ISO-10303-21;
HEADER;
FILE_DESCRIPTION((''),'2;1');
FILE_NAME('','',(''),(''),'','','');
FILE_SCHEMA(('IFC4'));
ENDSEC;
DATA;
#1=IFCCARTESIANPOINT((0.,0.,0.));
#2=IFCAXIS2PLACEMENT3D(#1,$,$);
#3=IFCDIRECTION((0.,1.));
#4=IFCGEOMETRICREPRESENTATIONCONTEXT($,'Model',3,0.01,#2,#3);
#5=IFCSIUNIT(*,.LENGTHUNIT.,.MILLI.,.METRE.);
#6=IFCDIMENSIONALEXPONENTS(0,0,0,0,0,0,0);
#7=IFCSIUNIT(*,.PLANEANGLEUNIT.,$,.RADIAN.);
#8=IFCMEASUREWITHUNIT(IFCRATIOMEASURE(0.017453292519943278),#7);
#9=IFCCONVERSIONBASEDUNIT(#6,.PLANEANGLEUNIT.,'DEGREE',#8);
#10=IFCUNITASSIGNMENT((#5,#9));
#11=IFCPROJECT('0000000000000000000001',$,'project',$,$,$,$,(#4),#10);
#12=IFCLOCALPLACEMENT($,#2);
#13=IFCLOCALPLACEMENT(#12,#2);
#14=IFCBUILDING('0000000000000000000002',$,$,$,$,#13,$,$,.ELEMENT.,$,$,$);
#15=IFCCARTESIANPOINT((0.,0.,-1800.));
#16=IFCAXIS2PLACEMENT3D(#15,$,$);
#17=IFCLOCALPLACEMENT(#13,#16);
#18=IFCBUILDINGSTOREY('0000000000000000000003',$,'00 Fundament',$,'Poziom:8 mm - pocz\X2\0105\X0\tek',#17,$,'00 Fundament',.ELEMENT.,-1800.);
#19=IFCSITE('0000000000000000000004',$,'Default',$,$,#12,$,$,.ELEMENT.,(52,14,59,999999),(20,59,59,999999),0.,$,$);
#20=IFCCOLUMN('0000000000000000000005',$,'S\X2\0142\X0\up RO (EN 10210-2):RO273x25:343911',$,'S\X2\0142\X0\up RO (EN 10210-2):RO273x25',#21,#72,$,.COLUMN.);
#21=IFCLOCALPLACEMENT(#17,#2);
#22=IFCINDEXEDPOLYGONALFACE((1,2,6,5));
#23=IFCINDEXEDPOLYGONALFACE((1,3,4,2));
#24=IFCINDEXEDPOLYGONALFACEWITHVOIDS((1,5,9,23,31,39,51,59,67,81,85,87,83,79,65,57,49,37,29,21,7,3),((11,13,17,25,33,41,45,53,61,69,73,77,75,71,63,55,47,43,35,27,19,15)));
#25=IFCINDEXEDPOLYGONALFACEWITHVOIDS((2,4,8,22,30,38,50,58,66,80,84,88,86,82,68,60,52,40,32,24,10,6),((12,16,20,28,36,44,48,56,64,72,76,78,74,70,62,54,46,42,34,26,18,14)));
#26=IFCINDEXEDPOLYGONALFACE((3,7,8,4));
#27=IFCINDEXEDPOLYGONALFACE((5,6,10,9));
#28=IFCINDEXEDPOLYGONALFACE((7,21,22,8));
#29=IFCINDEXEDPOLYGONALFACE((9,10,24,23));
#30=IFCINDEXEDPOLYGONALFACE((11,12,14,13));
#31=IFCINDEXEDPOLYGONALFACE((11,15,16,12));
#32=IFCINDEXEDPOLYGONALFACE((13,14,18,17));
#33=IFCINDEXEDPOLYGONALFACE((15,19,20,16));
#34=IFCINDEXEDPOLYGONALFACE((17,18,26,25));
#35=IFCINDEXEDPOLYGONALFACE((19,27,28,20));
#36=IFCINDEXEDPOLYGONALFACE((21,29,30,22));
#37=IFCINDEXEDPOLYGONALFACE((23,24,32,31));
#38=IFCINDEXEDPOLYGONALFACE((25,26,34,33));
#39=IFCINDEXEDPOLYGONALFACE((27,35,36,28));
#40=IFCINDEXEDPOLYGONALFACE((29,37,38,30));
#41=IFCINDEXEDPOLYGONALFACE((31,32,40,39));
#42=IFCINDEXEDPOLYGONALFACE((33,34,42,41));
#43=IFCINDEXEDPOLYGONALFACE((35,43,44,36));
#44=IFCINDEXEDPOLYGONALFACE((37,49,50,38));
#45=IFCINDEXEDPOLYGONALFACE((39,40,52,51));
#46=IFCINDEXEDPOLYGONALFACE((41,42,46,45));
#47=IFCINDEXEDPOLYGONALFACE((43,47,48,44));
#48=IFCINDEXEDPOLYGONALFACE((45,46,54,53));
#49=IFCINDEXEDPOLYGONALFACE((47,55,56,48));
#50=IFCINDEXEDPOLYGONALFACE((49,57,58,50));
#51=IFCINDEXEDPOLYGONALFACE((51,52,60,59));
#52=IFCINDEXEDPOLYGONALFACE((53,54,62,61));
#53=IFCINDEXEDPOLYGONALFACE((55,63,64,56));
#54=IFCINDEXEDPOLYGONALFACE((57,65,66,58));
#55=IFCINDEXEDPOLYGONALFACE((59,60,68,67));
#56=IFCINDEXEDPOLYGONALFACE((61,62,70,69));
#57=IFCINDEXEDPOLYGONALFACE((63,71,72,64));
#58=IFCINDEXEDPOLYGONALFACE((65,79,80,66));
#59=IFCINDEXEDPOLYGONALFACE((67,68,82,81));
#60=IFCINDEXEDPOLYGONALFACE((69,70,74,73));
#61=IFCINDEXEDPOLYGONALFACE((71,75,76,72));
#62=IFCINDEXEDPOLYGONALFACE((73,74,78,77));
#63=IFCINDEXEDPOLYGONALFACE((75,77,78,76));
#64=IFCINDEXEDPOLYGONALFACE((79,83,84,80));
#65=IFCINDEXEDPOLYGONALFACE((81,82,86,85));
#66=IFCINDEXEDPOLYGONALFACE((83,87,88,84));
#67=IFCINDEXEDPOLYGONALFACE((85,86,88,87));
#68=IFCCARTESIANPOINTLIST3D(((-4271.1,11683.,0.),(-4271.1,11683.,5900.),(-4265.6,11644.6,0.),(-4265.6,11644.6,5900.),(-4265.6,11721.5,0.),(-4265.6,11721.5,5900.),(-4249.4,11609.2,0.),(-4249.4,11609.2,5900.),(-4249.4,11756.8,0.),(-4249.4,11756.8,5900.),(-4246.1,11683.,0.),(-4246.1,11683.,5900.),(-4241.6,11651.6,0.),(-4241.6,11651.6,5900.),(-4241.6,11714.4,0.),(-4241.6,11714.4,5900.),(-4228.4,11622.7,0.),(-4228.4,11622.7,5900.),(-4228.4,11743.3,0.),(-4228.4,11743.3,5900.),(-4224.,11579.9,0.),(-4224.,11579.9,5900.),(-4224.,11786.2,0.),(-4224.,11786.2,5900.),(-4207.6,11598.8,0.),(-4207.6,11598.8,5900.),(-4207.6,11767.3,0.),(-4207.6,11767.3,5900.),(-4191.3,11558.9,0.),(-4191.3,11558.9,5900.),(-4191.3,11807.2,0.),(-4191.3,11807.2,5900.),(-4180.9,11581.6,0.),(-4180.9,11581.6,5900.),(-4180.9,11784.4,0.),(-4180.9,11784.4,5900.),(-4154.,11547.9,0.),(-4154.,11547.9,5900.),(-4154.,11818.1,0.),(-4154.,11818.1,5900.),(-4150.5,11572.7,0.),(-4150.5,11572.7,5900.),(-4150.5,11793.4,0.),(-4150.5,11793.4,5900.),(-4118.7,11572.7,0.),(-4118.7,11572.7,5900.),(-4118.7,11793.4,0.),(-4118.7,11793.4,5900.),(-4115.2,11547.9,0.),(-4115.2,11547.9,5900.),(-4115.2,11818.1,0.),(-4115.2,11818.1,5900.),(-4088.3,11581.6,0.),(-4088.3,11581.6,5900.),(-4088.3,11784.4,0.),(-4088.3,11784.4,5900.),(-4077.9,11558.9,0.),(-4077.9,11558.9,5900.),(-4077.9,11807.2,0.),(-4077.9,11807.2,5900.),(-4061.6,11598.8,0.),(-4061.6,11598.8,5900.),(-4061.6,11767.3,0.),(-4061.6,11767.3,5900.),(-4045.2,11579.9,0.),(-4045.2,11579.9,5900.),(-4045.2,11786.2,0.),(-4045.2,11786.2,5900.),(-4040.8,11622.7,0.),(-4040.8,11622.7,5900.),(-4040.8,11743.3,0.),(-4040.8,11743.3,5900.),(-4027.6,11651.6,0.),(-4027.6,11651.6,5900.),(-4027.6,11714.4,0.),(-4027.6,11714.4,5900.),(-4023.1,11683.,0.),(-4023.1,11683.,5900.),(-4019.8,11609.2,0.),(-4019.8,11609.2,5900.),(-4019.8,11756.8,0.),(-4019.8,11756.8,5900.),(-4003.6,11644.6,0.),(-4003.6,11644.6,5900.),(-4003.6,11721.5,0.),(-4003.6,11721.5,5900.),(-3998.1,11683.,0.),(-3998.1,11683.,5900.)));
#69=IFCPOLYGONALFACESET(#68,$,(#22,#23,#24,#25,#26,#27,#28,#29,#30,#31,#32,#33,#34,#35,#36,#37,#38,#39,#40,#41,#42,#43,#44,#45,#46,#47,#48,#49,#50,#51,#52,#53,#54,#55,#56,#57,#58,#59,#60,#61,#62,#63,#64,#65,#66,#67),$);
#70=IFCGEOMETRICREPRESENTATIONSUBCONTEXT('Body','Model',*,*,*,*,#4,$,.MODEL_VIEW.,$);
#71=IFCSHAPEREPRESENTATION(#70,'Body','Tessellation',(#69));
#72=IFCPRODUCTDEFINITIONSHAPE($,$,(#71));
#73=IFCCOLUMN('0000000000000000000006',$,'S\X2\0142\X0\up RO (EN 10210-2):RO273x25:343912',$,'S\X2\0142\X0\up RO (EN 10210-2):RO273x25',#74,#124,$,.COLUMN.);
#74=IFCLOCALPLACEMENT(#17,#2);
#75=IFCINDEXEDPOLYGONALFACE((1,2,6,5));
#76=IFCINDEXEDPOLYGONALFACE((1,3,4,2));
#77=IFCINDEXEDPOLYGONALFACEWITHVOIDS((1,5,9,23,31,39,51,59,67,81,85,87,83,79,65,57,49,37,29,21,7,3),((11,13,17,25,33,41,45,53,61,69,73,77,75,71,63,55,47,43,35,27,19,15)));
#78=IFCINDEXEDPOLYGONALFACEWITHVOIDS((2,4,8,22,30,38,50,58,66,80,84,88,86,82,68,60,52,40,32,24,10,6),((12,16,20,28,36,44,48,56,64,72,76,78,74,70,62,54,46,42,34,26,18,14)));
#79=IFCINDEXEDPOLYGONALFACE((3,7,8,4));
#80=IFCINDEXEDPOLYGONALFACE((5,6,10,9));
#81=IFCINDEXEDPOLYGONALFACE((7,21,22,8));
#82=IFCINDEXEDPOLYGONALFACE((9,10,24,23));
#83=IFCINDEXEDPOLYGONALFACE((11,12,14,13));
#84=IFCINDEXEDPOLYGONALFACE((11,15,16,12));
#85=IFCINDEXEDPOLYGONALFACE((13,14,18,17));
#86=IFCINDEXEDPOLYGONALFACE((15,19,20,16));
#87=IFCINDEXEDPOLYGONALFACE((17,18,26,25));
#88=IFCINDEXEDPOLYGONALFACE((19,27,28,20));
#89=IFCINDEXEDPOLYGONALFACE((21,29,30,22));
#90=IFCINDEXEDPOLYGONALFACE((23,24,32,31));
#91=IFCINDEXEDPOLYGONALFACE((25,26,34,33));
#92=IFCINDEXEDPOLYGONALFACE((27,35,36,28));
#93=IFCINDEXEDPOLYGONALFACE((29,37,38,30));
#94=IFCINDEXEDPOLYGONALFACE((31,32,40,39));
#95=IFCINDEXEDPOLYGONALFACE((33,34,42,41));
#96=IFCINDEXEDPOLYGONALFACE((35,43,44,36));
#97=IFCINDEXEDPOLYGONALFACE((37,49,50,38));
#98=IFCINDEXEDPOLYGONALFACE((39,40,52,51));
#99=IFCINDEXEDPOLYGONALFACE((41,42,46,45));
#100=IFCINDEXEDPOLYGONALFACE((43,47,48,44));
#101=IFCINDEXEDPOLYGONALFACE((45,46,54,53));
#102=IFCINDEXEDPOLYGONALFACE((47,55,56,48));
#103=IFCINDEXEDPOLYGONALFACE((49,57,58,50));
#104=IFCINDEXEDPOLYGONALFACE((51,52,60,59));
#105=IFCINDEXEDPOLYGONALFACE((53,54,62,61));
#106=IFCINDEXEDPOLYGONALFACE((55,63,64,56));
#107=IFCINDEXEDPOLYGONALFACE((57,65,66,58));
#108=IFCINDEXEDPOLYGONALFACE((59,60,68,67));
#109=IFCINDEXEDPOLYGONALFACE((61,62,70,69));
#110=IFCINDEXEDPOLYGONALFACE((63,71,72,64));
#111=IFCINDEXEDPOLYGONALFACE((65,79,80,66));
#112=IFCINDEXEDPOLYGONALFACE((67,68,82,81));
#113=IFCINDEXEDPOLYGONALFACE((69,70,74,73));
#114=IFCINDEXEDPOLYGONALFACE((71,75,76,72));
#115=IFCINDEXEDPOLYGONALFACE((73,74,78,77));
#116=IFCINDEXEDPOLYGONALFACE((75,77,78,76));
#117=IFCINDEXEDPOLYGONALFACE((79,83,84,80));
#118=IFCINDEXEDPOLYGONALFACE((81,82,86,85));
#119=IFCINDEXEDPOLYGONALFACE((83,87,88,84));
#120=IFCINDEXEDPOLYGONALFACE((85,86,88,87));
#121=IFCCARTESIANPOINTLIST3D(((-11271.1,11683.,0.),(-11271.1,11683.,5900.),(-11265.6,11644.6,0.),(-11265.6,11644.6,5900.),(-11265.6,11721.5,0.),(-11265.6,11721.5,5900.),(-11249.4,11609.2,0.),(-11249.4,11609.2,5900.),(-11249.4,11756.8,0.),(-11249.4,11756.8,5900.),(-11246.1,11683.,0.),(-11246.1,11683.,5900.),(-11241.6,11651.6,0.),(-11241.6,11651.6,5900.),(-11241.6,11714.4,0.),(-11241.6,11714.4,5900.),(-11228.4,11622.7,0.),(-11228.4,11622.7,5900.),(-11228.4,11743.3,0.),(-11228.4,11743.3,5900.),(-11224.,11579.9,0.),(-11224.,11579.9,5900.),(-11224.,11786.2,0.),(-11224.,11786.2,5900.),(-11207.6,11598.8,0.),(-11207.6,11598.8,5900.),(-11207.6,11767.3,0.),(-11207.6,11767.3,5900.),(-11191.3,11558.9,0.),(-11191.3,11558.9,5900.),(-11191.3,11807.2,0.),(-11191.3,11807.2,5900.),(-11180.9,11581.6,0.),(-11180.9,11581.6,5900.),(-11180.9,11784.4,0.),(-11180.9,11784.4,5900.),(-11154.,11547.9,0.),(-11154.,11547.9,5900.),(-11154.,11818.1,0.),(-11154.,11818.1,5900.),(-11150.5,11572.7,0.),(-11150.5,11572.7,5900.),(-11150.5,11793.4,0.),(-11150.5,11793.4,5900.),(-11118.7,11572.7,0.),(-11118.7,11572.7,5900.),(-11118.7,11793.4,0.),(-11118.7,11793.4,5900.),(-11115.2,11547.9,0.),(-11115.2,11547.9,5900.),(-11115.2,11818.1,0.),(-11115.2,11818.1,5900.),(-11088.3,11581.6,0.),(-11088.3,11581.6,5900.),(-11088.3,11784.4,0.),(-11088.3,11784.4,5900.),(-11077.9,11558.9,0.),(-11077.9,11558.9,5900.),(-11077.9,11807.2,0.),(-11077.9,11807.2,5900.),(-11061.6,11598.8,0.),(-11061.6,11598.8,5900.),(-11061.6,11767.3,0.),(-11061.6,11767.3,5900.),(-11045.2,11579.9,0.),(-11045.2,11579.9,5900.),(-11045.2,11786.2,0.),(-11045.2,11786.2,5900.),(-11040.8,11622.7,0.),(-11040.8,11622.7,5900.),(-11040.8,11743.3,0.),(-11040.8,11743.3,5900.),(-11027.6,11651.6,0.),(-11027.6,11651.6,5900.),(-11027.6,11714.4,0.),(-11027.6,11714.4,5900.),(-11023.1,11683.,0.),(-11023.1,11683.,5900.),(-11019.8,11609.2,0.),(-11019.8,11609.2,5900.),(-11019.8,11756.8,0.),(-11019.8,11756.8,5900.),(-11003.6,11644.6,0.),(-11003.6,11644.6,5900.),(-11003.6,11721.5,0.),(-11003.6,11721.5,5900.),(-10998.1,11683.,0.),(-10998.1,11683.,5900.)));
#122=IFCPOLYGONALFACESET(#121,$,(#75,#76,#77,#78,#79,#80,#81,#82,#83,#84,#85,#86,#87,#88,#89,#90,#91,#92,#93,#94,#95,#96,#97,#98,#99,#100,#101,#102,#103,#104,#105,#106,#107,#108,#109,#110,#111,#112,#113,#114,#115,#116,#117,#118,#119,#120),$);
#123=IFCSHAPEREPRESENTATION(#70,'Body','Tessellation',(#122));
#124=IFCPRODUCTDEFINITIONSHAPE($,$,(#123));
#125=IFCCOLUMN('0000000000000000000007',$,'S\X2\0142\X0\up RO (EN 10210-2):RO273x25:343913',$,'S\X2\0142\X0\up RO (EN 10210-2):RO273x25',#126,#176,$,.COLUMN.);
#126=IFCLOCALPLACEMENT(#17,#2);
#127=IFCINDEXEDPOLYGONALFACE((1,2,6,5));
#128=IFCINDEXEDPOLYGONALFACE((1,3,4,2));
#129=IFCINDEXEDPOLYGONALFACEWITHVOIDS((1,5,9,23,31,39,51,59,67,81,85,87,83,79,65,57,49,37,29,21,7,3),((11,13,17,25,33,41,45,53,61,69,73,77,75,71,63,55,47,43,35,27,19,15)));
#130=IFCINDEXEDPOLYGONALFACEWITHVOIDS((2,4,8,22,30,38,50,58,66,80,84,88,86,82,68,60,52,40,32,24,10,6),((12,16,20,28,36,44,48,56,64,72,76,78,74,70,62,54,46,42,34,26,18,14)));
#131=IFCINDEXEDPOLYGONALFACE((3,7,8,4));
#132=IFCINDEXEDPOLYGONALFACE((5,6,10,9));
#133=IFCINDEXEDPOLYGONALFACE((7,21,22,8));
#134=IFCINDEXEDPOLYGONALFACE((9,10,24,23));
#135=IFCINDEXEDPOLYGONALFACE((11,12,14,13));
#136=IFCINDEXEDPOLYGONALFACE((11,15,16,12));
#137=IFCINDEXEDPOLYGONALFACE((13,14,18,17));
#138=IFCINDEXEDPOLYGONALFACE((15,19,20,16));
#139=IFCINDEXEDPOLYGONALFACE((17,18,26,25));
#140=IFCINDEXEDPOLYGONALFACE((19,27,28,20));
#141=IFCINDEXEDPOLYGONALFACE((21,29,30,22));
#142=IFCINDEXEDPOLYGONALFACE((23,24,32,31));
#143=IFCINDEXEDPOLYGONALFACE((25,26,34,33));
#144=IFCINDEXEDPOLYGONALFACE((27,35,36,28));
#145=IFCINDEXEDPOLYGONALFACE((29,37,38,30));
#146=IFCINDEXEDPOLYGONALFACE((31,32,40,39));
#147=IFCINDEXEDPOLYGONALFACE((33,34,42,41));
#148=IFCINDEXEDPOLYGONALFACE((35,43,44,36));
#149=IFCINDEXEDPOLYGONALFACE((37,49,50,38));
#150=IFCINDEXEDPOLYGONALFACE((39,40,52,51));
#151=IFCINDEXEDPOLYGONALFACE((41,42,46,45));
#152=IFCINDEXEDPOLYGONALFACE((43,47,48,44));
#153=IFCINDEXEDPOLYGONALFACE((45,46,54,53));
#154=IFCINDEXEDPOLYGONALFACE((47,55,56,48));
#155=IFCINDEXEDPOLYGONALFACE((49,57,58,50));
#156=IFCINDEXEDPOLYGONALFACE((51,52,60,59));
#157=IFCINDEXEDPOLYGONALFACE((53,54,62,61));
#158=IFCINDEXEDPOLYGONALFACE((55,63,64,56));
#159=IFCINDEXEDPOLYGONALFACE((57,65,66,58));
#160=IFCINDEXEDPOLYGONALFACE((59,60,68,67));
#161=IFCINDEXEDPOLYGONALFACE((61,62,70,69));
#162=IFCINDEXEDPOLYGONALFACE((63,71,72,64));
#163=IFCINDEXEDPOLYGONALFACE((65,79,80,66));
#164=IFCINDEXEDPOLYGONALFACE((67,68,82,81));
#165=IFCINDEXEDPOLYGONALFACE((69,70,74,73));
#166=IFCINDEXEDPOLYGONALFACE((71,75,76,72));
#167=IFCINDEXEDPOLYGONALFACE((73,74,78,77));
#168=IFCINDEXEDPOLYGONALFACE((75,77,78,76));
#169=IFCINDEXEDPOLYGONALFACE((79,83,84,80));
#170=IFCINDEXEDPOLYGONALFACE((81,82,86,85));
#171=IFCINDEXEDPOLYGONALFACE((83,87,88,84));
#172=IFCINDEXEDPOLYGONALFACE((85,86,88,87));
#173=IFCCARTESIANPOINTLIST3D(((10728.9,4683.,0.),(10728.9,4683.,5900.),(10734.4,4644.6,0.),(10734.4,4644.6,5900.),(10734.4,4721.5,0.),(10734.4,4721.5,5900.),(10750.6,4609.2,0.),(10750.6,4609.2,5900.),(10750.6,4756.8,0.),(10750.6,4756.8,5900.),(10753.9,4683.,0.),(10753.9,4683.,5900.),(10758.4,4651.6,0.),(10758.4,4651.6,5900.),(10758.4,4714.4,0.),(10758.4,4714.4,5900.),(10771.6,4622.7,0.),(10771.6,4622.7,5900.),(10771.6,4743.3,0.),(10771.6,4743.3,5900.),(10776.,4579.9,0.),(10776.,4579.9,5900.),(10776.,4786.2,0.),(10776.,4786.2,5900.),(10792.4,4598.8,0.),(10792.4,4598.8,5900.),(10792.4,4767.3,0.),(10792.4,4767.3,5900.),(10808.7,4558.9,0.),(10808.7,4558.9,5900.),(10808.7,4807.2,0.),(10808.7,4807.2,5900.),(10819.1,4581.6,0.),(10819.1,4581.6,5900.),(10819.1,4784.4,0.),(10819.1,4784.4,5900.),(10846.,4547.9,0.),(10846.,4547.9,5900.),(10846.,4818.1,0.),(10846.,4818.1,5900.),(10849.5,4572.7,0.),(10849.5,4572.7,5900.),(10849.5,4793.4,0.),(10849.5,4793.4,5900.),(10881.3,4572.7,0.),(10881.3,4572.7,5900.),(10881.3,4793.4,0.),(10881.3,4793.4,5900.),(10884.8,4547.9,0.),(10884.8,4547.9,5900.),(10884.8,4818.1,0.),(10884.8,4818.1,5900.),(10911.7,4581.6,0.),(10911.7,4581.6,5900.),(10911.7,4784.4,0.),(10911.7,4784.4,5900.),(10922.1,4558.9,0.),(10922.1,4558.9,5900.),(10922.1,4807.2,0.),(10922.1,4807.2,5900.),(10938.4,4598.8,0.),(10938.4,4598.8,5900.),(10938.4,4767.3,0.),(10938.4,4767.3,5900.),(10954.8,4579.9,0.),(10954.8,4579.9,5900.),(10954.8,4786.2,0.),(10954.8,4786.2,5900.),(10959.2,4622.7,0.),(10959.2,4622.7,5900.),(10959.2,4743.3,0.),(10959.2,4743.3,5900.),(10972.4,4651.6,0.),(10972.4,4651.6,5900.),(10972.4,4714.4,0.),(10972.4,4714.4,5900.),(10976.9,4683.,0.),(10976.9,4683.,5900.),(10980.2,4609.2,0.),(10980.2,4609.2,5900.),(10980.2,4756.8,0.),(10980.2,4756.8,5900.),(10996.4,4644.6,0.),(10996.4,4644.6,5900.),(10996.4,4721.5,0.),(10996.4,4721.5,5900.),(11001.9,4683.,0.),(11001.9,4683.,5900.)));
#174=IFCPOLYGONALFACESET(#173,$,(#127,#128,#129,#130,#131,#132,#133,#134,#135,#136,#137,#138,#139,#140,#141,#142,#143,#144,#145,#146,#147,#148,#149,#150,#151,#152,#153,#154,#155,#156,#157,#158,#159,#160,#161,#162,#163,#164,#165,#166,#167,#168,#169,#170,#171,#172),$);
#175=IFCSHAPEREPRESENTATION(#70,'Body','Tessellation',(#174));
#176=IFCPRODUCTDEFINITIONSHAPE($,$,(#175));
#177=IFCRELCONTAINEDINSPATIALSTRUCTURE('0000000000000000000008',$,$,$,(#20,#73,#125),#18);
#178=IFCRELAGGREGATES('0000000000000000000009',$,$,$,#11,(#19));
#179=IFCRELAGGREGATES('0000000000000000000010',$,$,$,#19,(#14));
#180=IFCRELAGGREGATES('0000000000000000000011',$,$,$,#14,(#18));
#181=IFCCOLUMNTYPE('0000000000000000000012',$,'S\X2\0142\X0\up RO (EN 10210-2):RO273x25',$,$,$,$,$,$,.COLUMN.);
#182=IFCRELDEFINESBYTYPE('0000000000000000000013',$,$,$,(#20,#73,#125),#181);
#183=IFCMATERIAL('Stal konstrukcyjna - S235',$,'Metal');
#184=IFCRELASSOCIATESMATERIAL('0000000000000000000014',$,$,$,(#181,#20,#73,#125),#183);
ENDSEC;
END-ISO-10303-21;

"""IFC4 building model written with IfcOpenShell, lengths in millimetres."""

from ifc_helpers import new_model, entity, si_unit, converted_unit, direction, frame, origin, place, context, subcontext, project, spatial, arc, indexed_curve, outline, extrude, source, transform, mapped, material, type_object, type_shapes, element, save


model = new_model("IFC4")

# Units and contexts
model_context = context("Model", 3, precision=0.01, world=origin(), true_north=direction((0.0, 1.0)))
body_context = subcontext(model_context, "Body", "Model", "MODEL_VIEW")
ifc_project = project(units=[si_unit("LENGTHUNIT", "METRE", prefix="MILLI"), converted_unit("PLANEANGLEUNIT", "DEGREE", entity("IfcRatioMeasure", 0.017453292519943278), si_unit("PLANEANGLEUNIT", "RADIAN"), dimensions=[0, 0, 0, 0, 0, 0, 0])], contexts=[model_context])

# Site, building, storey
site_placement = place(None, origin())
site = spatial("IfcSite", under=ifc_project, at=site_placement, Name="Default", CompositionType="ELEMENT", RefLatitude=(52, 14, 59, 999999), RefLongitude=(20, 59, 59, 999999), RefElevation=0.0)
building_placement = place(site_placement, origin())
building = spatial("IfcBuilding", under=site, at=building_placement, CompositionType="ELEMENT")
storey_placement = place(building_placement, frame((0.0, 0.0, -1800.0)))
storey = spatial("IfcBuildingStorey", under=building, at=storey_placement, Name="00 Fundament", ObjectType="Poziom:8 mm - początek", LongName="00 Fundament", CompositionType="ELEMENT", Elevation=-1800.0)

# Columns
ifc_material_1 = material(Name="Stal konstrukcyjna - S235", Category="Metal")
column_type = type_object("IfcColumnType", Name="Słup RO (EN 10210-2):RO273x25", PredefinedType="COLUMN", material=ifc_material_1)
shared_shape = source(origin(), body_context, "Body", "SweptSolid", [
    extrude(outline(indexed_curve([(-136.5, 0.0), (0.0, -136.5), (136.5, 0.0), (0.0, 136.5)], segments=[arc(1, 2, 3), arc(3, 4, 1)], self_intersect=False), holes=[indexed_curve([(-111.5, 0.0), (0.0, 111.5), (111.5, 0.0), (0.0, -111.5)], segments=[arc(1, 2, 3), arc(3, 4, 1)], self_intersect=False)]), frame((0.0, 0.0, -1800.0)), (0.0, 0.0, 1.0), 5900.0),
])
type_shapes(column_type, [shared_shape])
for number, where, name in (
    (1, (-4134.6, 11683.0, 1800.0), "Słup RO (EN 10210-2):RO273x25:343911"),
    (2, (-11134.6, 11683.0, 1800.0), "Słup RO (EN 10210-2):RO273x25:343912"),
    (3, (10865.4, 4683.0, 1800.0), "Słup RO (EN 10210-2):RO273x25:343913"),
):
    element("IfcColumn", number, at=place(storey_placement, frame(where)), inside=storey, type_object=column_type, material=ifc_material_1, Name=name, ObjectType="Słup RO (EN 10210-2):RO273x25", PredefinedType="COLUMN", context=body_context, shape_type="MappedRepresentation", body=[
        mapped(shared_shape, transform((0.0, 0.0, 0.0), scale=1.0)),
    ])

save(model, "model.ifc")
